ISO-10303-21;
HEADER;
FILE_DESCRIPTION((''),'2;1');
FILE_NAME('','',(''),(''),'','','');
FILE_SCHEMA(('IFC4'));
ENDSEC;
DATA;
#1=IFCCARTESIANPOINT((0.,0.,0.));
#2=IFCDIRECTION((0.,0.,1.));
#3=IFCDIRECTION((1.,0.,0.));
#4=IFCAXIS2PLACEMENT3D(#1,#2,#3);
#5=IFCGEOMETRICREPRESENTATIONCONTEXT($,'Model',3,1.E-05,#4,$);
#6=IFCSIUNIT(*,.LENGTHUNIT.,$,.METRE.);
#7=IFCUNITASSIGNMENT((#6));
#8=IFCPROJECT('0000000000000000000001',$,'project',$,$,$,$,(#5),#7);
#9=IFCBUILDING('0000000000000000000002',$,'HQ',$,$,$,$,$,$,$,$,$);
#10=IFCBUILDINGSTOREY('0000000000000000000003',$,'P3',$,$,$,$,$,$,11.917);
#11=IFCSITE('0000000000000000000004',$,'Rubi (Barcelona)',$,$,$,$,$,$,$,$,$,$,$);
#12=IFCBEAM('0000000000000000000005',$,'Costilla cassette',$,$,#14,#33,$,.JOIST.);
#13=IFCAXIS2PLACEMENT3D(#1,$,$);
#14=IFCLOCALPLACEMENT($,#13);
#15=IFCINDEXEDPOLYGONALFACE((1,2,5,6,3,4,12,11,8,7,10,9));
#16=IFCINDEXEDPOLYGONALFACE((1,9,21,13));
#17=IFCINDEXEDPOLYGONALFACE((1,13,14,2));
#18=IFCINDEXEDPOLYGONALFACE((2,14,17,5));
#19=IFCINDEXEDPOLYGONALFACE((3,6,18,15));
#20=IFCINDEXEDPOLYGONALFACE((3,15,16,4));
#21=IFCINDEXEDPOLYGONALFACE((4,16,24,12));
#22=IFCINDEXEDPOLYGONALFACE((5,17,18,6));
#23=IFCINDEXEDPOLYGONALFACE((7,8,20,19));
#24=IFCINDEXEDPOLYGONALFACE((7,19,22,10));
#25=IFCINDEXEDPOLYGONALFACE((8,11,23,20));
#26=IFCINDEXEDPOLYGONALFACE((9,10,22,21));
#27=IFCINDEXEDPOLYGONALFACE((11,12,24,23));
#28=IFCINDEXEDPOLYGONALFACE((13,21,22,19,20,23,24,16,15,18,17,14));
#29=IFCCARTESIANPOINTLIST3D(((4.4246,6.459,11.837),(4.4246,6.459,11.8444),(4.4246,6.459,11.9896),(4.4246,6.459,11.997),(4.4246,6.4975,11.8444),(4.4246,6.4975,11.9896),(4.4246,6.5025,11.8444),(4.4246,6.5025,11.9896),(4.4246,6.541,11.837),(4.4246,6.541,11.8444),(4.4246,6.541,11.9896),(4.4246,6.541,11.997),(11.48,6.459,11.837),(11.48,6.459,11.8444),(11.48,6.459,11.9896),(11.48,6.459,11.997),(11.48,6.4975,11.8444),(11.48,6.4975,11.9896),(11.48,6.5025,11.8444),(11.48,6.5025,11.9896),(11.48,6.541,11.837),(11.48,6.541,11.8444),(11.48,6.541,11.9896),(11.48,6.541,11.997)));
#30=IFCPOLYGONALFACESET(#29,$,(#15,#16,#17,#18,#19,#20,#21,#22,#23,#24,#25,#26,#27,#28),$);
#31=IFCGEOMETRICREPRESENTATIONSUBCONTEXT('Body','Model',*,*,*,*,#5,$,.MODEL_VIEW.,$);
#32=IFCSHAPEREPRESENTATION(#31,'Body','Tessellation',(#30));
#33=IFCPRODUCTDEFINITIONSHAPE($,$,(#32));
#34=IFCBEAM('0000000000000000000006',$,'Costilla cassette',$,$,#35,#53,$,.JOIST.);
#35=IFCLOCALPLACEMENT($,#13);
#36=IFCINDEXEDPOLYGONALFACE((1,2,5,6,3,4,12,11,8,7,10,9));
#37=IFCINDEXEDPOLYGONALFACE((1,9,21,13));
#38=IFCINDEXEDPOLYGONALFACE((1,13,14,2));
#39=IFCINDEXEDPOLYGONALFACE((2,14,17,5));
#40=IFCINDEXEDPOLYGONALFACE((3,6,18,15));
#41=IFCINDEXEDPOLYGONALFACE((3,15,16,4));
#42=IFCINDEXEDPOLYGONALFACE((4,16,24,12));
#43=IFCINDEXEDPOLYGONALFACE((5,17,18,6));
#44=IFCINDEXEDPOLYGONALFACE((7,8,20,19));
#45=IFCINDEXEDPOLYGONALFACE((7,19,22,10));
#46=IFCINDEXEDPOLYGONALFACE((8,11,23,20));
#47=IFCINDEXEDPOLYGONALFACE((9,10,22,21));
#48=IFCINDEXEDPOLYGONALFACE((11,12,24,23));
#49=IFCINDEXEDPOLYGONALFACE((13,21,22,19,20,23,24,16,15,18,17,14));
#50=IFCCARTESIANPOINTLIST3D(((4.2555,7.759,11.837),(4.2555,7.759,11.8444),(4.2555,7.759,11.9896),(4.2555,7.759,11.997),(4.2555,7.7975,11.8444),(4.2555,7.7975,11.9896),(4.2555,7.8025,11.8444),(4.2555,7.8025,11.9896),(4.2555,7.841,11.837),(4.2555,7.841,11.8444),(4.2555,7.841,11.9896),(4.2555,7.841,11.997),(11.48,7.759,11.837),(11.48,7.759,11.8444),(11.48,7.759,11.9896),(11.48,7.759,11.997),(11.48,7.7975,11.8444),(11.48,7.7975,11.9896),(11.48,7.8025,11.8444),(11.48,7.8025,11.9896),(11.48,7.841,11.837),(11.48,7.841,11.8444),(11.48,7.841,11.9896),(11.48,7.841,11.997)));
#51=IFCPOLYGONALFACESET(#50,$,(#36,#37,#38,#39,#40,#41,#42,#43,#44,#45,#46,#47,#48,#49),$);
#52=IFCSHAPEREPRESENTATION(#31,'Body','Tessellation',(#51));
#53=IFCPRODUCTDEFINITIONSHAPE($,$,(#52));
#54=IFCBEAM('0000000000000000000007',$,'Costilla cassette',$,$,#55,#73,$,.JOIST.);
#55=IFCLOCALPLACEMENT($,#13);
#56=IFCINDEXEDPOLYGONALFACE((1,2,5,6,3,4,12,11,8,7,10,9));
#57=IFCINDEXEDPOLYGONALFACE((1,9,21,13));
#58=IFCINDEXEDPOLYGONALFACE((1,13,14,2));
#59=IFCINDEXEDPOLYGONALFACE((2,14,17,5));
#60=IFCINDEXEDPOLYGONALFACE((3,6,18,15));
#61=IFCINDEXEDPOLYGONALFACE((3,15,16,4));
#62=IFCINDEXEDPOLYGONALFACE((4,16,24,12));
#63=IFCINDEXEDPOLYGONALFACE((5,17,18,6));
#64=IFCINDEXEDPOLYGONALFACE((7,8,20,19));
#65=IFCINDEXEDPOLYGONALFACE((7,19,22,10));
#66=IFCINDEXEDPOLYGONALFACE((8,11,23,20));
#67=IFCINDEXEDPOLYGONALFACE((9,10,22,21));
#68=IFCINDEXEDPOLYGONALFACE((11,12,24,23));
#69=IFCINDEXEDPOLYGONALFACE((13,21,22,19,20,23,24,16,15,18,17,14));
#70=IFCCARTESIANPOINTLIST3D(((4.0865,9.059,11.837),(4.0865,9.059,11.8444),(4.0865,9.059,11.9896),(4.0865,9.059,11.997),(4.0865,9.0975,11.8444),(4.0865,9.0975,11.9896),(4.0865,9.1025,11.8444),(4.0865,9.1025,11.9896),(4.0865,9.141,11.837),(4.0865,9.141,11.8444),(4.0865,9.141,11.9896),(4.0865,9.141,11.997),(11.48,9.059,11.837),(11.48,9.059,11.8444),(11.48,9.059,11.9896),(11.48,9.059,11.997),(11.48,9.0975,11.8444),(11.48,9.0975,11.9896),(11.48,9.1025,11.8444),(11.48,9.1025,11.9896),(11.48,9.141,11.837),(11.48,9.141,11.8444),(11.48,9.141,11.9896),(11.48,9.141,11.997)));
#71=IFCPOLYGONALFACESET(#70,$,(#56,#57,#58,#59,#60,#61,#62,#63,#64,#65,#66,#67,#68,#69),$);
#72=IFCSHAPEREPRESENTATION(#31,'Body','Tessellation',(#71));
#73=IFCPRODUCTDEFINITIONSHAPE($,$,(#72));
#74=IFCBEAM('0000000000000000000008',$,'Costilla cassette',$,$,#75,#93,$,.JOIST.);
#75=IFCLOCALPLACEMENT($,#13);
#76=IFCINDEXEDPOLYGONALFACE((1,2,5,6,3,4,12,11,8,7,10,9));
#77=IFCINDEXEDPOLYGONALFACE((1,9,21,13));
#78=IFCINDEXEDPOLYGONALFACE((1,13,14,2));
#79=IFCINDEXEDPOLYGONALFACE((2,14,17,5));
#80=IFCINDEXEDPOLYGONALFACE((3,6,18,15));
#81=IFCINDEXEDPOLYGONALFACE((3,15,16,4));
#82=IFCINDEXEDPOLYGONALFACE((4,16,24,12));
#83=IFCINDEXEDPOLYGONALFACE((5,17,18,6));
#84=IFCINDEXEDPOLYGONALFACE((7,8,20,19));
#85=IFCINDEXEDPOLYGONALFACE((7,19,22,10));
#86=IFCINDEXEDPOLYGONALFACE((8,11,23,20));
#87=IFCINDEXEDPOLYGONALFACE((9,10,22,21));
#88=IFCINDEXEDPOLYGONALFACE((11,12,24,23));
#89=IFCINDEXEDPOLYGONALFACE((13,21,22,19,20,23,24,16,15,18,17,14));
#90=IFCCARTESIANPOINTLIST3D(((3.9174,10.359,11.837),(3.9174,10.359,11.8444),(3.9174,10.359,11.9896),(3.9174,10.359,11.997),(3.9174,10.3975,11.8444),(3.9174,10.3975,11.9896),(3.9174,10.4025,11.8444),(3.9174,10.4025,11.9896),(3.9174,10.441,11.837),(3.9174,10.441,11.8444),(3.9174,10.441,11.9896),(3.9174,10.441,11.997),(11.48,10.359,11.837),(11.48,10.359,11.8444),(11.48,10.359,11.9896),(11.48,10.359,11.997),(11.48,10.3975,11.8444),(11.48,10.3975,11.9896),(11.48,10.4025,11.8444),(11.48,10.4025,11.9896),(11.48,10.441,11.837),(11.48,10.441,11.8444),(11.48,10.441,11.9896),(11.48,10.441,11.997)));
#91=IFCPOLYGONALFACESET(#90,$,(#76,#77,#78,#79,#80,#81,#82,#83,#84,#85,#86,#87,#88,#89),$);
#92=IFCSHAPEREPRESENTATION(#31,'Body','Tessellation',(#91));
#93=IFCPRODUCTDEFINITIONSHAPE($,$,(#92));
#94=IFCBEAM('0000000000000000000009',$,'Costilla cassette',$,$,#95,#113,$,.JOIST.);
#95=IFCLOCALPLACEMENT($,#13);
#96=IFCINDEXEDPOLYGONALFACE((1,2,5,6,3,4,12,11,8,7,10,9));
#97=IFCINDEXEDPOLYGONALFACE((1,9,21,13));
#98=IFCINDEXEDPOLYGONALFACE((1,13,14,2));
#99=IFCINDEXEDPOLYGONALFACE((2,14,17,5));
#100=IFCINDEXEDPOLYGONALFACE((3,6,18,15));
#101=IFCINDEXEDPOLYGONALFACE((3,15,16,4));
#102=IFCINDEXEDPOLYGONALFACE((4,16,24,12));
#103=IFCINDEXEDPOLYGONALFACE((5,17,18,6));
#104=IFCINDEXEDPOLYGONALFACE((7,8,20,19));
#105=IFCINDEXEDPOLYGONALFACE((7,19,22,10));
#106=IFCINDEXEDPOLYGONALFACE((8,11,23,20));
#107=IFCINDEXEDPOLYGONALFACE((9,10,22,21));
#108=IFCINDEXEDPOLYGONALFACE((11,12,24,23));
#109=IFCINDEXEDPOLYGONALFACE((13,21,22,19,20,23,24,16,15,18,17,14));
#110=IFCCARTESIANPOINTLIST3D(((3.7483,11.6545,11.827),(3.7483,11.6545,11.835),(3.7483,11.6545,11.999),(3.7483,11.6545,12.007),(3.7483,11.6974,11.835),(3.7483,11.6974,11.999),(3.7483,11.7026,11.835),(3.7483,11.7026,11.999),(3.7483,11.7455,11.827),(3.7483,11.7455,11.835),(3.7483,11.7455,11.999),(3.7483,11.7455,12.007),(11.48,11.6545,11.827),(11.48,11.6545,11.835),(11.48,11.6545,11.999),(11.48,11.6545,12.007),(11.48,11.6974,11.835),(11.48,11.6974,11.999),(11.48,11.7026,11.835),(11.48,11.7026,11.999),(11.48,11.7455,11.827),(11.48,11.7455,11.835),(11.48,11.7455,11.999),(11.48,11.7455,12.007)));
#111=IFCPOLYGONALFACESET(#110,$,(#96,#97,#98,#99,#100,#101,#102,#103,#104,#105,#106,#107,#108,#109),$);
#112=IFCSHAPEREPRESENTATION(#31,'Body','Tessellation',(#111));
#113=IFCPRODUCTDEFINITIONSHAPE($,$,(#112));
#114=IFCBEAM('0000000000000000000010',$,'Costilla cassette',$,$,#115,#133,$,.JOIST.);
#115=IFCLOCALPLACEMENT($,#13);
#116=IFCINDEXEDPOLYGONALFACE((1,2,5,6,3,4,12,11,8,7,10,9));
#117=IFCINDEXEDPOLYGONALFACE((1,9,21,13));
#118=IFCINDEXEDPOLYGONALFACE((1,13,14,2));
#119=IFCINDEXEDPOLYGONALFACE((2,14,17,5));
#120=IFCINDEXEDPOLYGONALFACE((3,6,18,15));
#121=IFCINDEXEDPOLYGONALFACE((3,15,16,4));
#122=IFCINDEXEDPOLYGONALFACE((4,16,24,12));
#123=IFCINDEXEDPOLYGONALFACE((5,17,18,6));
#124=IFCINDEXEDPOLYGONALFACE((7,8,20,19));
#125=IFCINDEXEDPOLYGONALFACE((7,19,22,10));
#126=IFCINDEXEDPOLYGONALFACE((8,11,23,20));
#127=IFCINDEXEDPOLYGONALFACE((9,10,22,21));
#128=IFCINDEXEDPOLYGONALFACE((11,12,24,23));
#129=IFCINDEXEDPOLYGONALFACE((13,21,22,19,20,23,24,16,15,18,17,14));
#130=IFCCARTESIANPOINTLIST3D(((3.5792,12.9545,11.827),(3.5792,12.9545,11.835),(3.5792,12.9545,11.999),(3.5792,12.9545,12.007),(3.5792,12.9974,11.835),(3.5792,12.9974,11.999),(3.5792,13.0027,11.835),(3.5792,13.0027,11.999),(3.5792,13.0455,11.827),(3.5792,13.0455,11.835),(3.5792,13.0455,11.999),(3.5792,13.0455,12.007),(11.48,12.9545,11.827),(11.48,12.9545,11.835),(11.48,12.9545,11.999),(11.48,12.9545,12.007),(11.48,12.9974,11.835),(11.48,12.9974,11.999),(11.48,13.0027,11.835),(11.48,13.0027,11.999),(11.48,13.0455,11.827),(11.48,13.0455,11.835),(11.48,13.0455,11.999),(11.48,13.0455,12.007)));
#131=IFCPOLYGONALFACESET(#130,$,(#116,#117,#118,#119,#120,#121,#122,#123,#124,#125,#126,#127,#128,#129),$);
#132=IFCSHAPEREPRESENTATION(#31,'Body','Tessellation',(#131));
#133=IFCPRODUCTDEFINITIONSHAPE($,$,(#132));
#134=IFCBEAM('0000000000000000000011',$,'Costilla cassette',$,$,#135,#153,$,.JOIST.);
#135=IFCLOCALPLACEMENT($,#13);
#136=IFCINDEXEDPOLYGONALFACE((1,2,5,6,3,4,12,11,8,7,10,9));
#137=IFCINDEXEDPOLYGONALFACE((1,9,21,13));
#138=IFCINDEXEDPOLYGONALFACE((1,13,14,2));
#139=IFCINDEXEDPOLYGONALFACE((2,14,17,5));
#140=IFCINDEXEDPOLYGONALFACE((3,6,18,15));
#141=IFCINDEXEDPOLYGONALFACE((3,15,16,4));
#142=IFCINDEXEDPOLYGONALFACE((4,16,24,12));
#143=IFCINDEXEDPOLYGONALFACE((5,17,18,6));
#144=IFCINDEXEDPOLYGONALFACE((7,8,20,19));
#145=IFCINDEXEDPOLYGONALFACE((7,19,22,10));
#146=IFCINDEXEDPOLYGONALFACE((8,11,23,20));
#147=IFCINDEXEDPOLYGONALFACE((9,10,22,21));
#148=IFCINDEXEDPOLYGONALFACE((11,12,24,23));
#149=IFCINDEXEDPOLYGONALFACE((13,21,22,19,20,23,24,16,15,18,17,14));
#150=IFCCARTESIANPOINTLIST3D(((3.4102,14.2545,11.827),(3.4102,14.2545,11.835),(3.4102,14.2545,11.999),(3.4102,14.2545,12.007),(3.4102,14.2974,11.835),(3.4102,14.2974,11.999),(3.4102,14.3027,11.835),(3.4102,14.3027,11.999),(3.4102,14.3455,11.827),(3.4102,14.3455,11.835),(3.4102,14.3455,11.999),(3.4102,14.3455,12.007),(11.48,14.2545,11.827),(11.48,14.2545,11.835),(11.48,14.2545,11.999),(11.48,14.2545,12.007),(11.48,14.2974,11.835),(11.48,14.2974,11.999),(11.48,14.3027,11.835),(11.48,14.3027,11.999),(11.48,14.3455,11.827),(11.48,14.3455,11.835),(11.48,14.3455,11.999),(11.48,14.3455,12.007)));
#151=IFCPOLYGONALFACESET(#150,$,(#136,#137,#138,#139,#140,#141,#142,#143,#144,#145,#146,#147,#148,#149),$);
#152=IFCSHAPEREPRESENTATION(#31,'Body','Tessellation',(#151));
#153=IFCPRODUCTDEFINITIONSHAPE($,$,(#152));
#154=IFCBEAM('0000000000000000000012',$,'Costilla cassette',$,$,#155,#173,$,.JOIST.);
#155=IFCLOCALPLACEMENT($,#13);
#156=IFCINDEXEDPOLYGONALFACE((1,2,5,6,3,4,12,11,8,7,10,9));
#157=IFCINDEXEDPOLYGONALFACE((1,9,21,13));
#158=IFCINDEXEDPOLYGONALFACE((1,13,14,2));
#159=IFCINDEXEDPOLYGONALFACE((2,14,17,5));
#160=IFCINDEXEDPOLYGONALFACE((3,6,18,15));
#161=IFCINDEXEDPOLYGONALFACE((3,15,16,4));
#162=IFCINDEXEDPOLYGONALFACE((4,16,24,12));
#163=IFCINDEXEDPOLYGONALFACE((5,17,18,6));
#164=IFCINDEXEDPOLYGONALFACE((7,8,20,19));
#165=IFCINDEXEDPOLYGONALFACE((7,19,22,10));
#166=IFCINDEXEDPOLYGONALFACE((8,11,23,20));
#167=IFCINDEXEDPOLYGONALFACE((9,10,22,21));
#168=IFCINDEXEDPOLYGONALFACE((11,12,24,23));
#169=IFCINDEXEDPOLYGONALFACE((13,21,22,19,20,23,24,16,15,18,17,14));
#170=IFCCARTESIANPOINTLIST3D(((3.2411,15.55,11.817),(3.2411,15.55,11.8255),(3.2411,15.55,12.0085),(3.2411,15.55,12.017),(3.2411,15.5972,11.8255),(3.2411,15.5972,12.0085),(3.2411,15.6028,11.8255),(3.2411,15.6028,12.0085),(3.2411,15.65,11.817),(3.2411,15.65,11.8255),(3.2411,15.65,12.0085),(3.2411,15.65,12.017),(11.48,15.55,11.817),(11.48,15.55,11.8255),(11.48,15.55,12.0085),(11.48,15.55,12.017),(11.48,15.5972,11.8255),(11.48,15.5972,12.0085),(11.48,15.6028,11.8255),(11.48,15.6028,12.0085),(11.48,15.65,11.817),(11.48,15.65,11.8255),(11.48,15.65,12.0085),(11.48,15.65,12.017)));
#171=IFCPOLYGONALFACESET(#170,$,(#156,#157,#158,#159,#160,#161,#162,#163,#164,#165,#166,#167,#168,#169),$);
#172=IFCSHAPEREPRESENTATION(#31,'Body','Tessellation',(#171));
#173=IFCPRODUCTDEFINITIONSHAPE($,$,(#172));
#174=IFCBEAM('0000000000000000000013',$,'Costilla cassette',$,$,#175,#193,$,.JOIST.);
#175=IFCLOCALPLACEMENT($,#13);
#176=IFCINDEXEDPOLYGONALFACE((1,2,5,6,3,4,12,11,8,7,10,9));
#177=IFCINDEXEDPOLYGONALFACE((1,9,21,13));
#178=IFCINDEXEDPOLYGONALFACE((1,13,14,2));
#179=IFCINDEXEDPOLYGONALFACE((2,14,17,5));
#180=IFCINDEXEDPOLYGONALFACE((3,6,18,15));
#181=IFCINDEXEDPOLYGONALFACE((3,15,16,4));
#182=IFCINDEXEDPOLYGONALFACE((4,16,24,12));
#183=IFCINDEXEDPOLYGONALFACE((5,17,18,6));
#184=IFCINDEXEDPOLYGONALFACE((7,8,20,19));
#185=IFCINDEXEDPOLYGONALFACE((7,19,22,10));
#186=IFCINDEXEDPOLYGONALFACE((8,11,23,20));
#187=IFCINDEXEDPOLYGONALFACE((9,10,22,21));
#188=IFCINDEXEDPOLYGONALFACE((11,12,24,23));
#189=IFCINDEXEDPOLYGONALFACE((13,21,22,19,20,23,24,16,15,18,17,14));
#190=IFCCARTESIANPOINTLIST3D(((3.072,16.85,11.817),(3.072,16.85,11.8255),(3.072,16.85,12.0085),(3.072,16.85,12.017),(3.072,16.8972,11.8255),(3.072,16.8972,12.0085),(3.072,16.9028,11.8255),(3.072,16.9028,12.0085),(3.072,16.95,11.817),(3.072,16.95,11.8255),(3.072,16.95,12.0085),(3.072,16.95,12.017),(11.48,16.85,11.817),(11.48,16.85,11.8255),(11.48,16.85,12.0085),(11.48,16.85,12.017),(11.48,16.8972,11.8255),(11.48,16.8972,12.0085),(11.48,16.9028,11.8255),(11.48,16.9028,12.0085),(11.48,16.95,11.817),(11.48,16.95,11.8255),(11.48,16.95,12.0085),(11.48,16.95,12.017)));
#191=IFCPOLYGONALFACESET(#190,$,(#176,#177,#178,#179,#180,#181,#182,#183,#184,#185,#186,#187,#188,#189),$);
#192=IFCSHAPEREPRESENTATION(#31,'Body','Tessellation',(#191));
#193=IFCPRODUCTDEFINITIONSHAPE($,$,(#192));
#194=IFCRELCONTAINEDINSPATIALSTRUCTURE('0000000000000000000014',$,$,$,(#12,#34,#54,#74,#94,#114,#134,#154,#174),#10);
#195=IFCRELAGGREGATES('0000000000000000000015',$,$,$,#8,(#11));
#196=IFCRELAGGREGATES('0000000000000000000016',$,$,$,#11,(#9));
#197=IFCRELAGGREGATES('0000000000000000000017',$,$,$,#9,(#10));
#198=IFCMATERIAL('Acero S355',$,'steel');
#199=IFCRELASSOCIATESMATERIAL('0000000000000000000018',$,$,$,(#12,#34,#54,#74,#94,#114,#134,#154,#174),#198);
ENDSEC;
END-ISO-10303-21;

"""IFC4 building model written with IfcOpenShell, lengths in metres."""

from ifc_helpers import new_model, si_unit, frame, origin_with_axes, place, context, subcontext, project, spatial, i_section, extrude, material, element, save


model = new_model("IFC4")

# Units and contexts
model_context = context("Model", 3, precision=1e-05, world=origin_with_axes())
body_context = subcontext(model_context, "Body", "Model", "MODEL_VIEW")
ifc_project = project(units=[si_unit("LENGTHUNIT", "METRE")], contexts=[model_context])

# Site, building, storey
site = spatial("IfcSite", under=ifc_project, Name="Rubi (Barcelona)")
building = spatial("IfcBuilding", under=site, Name="HQ")
storey = spatial("IfcBuildingStorey", under=building, Name="P3", Elevation=11.917)

# Beams
ifc_material_1 = material(Name="Acero S355", Category="steel")
beam_1_placement = place(None, origin_with_axes())
element("IfcBeam", 1, at=beam_1_placement, inside=storey, material=ifc_material_1, Name="Costilla cassette", PredefinedType="JOIST", context=body_context, shape_type="SweptSolid", body=[
    extrude(i_section(OverallWidth=0.082, OverallDepth=0.16, WebThickness=0.005, FlangeThickness=0.0074), frame((4.4246, 6.5, 11.917), z_axis=(1.0, 0.0, 0.0), x_axis=(0.0, 1.0, 0.0)), (0.0, 0.0, 1.0), 7.0554),
])
beam_2_placement = place(None, origin_with_axes())
element("IfcBeam", 2, at=beam_2_placement, inside=storey, material=ifc_material_1, Name="Costilla cassette", PredefinedType="JOIST", context=body_context, shape_type="SweptSolid", body=[
    extrude(i_section(OverallWidth=0.082, OverallDepth=0.16, WebThickness=0.005, FlangeThickness=0.0074), frame((4.2555, 7.8, 11.917), z_axis=(1.0, 0.0, 0.0), x_axis=(0.0, 1.0, 0.0)), (0.0, 0.0, 1.0), 7.2245),
])
beam_3_placement = place(None, origin_with_axes())
element("IfcBeam", 3, at=beam_3_placement, inside=storey, material=ifc_material_1, Name="Costilla cassette", PredefinedType="JOIST", context=body_context, shape_type="SweptSolid", body=[
    extrude(i_section(OverallWidth=0.082, OverallDepth=0.16, WebThickness=0.005, FlangeThickness=0.0074), frame((4.0865, 9.1, 11.917), z_axis=(1.0, 0.0, 0.0), x_axis=(0.0, 1.0, 0.0)), (0.0, 0.0, 1.0), 7.3935),
])
beam_4_placement = place(None, origin_with_axes())
element("IfcBeam", 4, at=beam_4_placement, inside=storey, material=ifc_material_1, Name="Costilla cassette", PredefinedType="JOIST", context=body_context, shape_type="SweptSolid", body=[
    extrude(i_section(OverallWidth=0.082, OverallDepth=0.16, WebThickness=0.005, FlangeThickness=0.0074), frame((3.9174, 10.4, 11.917), z_axis=(1.0, 0.0, 0.0), x_axis=(0.0, 1.0, 0.0)), (0.0, 0.0, 1.0), 7.5626),
])
beam_5_placement = place(None, origin_with_axes())
element("IfcBeam", 5, at=beam_5_placement, inside=storey, material=ifc_material_1, Name="Costilla cassette", PredefinedType="JOIST", context=body_context, shape_type="SweptSolid", body=[
    extrude(i_section(OverallWidth=0.091, OverallDepth=0.18, WebThickness=0.0053, FlangeThickness=0.008), frame((3.7483, 11.7, 11.917), z_axis=(1.0, 0.0, 0.0), x_axis=(0.0, 1.0, 0.0)), (0.0, 0.0, 1.0), 7.7317),
])
beam_6_placement = place(None, origin_with_axes())
element("IfcBeam", 6, at=beam_6_placement, inside=storey, material=ifc_material_1, Name="Costilla cassette", PredefinedType="JOIST", context=body_context, shape_type="SweptSolid", body=[
    extrude(i_section(OverallWidth=0.091, OverallDepth=0.18, WebThickness=0.0053, FlangeThickness=0.008), frame((3.5792, 13.0, 11.917), z_axis=(1.0, 0.0, 0.0), x_axis=(0.0, 1.0, 0.0)), (0.0, 0.0, 1.0), 7.9008),
])
beam_7_placement = place(None, origin_with_axes())
element("IfcBeam", 7, at=beam_7_placement, inside=storey, material=ifc_material_1, Name="Costilla cassette", PredefinedType="JOIST", context=body_context, shape_type="SweptSolid", body=[
    extrude(i_section(OverallWidth=0.091, OverallDepth=0.18, WebThickness=0.0053, FlangeThickness=0.008), frame((3.4102, 14.3, 11.917), z_axis=(1.0, 0.0, 0.0), x_axis=(0.0, 1.0, 0.0)), (0.0, 0.0, 1.0), 8.0698),
])
beam_8_placement = place(None, origin_with_axes())
element("IfcBeam", 8, at=beam_8_placement, inside=storey, material=ifc_material_1, Name="Costilla cassette", PredefinedType="JOIST", context=body_context, shape_type="SweptSolid", body=[
    extrude(i_section(OverallWidth=0.1, OverallDepth=0.2, WebThickness=0.0056, FlangeThickness=0.0085), frame((3.2411, 15.6, 11.917), z_axis=(1.0, 0.0, 0.0), x_axis=(0.0, 1.0, 0.0)), (0.0, 0.0, 1.0), 8.2389),
])
beam_9_placement = place(None, origin_with_axes())
element("IfcBeam", 9, at=beam_9_placement, inside=storey, material=ifc_material_1, Name="Costilla cassette", PredefinedType="JOIST", context=body_context, shape_type="SweptSolid", body=[
    extrude(i_section(OverallWidth=0.1, OverallDepth=0.2, WebThickness=0.0056, FlangeThickness=0.0085), frame((3.072, 16.9, 11.917), z_axis=(1.0, 0.0, 0.0), x_axis=(0.0, 1.0, 0.0)), (0.0, 0.0, 1.0), 8.408),
])

save(model, "model.ifc")
